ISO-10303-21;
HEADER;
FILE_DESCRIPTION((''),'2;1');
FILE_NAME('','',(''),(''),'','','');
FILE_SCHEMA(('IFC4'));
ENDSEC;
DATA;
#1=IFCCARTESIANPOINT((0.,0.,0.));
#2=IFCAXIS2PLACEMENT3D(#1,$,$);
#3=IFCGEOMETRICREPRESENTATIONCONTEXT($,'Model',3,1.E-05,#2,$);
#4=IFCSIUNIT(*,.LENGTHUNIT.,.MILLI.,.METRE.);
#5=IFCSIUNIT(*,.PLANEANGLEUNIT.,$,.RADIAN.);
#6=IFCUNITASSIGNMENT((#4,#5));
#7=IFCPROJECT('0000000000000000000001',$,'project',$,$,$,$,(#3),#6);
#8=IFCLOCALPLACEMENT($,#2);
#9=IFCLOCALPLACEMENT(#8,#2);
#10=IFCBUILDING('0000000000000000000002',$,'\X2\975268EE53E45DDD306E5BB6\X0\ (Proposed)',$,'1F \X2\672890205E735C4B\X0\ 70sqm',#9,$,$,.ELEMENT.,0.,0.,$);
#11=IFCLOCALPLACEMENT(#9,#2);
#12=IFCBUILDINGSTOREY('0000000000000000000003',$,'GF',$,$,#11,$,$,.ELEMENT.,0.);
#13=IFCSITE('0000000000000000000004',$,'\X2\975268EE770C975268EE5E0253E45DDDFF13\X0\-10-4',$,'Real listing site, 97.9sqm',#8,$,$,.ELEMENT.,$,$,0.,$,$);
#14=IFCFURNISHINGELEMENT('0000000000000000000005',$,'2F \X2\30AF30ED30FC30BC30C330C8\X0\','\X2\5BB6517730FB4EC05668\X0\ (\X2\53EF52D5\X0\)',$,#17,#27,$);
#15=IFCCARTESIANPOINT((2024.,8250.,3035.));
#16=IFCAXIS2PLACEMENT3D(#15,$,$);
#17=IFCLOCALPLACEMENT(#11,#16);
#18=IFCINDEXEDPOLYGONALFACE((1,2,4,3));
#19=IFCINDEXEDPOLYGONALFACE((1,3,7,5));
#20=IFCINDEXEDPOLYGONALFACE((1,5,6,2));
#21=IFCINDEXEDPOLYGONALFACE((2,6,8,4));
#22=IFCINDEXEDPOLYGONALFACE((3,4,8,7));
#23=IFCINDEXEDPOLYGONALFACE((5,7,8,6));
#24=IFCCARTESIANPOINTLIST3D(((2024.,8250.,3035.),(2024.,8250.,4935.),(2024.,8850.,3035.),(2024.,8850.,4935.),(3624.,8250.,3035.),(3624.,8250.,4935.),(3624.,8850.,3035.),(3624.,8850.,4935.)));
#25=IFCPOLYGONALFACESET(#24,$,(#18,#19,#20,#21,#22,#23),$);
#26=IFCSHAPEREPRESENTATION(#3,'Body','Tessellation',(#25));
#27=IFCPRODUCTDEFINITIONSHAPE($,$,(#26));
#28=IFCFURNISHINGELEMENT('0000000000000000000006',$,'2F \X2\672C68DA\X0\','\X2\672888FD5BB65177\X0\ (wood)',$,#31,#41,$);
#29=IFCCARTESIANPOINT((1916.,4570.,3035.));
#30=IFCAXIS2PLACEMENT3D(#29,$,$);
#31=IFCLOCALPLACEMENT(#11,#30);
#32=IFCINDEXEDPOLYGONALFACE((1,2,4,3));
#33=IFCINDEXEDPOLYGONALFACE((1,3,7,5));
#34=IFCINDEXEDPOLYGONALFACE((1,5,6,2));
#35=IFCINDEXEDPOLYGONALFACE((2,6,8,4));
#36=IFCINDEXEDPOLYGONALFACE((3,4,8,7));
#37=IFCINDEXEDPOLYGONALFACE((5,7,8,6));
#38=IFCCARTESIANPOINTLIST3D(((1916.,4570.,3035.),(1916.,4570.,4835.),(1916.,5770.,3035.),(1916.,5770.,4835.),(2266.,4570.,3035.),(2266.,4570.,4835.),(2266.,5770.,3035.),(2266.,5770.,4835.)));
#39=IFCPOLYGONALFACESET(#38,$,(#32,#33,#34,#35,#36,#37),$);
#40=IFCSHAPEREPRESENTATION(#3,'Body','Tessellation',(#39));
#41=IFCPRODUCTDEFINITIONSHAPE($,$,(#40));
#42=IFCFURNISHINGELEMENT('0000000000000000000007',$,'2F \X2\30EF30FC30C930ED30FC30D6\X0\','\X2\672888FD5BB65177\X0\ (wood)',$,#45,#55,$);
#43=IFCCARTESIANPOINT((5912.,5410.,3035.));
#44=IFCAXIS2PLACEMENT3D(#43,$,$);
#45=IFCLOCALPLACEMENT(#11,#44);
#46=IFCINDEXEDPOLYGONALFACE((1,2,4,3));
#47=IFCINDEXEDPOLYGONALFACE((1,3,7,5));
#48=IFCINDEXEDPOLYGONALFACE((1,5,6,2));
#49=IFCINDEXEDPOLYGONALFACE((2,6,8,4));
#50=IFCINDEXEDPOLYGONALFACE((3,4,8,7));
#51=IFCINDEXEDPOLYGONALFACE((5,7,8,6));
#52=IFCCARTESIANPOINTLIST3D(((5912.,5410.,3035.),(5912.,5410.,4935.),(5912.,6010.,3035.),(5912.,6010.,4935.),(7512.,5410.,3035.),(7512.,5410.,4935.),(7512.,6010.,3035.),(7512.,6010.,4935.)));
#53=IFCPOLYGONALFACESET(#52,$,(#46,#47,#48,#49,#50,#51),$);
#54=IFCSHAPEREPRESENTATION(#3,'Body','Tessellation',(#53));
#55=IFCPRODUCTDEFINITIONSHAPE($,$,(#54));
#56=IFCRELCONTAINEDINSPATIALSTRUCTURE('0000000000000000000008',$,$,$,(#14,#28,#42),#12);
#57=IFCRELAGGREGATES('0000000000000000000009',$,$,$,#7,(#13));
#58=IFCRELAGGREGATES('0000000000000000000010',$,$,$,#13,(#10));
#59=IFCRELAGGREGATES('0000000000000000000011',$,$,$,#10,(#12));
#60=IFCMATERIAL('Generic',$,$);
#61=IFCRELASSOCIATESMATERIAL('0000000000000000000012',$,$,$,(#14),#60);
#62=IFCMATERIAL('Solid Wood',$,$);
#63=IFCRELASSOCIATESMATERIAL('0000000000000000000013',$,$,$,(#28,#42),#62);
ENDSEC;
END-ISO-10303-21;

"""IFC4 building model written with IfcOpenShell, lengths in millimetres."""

from ifc_helpers import new_model, si_unit, frame, frame_2d, origin, place, context, project, spatial, rectangle, extrude, material, element, save


model = new_model("IFC4")

# Units and contexts
model_context = context("Model", 3, precision=1e-05, world=origin())
ifc_project = project(units=[si_unit("LENGTHUNIT", "METRE", prefix="MILLI"), si_unit("PLANEANGLEUNIT", "RADIAN")], contexts=[model_context])

# Site, building, storey
site_placement = place(None, origin())
site = spatial("IfcSite", under=ifc_project, at=site_placement, Name="青森県青森市古川３-10-4", ObjectType="Real listing site, 97.9sqm", CompositionType="ELEMENT", RefElevation=0.0)
building_placement = place(site_placement, origin())
building = spatial("IfcBuilding", under=site, at=building_placement, Name="青森古川の家 (Proposed)", ObjectType="1F 木造平屋 70sqm", CompositionType="ELEMENT", ElevationOfRefHeight=0.0, ElevationOfTerrain=0.0)
storey_placement = place(building_placement, origin())
storey = spatial("IfcBuildingStorey", under=building, at=storey_placement, Name="GF", CompositionType="ELEMENT", Elevation=0.0)

# Shared definitions
ifc_material_1 = material(Name="Solid Wood")

# Shared definitions
ifc_material_2 = material(Name="Generic")

# Furnishing elements
furnishing_1_placement = place(storey_placement, frame((2024.0, 8250.0, 3035.0)))
element("IfcFurnishingElement", 1, at=furnishing_1_placement, inside=storey, material=ifc_material_2, Name="2F クローゼット", Description="家具・什器 (可動)", context=model_context, shape_type="SweptSolid", body=[
    extrude(rectangle(XDim=1600.0, YDim=600.0, at=frame_2d((800.0, 300.0))), frame((2024.0, 8250.0, 3035.0)), (0.0, 0.0, 1.0), 1900.0),
])
furnishing_2_placement = place(storey_placement, frame((1916.0, 4570.0, 3035.0)))
element("IfcFurnishingElement", 2, at=furnishing_2_placement, inside=storey, material=ifc_material_1, Name="2F 本棚", Description="木製家具 (wood)", context=model_context, shape_type="SweptSolid", body=[
    extrude(rectangle(XDim=350.0, YDim=1200.0, at=frame_2d((175.0, 600.0))), frame((1916.0, 4570.0, 3035.0)), (0.0, 0.0, 1.0), 1800.0),
])
furnishing_3_placement = place(storey_placement, frame((5912.0, 5410.0, 3035.0)))
element("IfcFurnishingElement", 3, at=furnishing_3_placement, inside=storey, material=ifc_material_1, Name="2F ワードローブ", Description="木製家具 (wood)", context=model_context, shape_type="SweptSolid", body=[
    extrude(rectangle(XDim=1600.0, YDim=600.0, at=frame_2d((800.0, 300.0))), frame((5912.0, 5410.0, 3035.0)), (0.0, 0.0, 1.0), 1900.0),
])

save(model, "model.ifc")
